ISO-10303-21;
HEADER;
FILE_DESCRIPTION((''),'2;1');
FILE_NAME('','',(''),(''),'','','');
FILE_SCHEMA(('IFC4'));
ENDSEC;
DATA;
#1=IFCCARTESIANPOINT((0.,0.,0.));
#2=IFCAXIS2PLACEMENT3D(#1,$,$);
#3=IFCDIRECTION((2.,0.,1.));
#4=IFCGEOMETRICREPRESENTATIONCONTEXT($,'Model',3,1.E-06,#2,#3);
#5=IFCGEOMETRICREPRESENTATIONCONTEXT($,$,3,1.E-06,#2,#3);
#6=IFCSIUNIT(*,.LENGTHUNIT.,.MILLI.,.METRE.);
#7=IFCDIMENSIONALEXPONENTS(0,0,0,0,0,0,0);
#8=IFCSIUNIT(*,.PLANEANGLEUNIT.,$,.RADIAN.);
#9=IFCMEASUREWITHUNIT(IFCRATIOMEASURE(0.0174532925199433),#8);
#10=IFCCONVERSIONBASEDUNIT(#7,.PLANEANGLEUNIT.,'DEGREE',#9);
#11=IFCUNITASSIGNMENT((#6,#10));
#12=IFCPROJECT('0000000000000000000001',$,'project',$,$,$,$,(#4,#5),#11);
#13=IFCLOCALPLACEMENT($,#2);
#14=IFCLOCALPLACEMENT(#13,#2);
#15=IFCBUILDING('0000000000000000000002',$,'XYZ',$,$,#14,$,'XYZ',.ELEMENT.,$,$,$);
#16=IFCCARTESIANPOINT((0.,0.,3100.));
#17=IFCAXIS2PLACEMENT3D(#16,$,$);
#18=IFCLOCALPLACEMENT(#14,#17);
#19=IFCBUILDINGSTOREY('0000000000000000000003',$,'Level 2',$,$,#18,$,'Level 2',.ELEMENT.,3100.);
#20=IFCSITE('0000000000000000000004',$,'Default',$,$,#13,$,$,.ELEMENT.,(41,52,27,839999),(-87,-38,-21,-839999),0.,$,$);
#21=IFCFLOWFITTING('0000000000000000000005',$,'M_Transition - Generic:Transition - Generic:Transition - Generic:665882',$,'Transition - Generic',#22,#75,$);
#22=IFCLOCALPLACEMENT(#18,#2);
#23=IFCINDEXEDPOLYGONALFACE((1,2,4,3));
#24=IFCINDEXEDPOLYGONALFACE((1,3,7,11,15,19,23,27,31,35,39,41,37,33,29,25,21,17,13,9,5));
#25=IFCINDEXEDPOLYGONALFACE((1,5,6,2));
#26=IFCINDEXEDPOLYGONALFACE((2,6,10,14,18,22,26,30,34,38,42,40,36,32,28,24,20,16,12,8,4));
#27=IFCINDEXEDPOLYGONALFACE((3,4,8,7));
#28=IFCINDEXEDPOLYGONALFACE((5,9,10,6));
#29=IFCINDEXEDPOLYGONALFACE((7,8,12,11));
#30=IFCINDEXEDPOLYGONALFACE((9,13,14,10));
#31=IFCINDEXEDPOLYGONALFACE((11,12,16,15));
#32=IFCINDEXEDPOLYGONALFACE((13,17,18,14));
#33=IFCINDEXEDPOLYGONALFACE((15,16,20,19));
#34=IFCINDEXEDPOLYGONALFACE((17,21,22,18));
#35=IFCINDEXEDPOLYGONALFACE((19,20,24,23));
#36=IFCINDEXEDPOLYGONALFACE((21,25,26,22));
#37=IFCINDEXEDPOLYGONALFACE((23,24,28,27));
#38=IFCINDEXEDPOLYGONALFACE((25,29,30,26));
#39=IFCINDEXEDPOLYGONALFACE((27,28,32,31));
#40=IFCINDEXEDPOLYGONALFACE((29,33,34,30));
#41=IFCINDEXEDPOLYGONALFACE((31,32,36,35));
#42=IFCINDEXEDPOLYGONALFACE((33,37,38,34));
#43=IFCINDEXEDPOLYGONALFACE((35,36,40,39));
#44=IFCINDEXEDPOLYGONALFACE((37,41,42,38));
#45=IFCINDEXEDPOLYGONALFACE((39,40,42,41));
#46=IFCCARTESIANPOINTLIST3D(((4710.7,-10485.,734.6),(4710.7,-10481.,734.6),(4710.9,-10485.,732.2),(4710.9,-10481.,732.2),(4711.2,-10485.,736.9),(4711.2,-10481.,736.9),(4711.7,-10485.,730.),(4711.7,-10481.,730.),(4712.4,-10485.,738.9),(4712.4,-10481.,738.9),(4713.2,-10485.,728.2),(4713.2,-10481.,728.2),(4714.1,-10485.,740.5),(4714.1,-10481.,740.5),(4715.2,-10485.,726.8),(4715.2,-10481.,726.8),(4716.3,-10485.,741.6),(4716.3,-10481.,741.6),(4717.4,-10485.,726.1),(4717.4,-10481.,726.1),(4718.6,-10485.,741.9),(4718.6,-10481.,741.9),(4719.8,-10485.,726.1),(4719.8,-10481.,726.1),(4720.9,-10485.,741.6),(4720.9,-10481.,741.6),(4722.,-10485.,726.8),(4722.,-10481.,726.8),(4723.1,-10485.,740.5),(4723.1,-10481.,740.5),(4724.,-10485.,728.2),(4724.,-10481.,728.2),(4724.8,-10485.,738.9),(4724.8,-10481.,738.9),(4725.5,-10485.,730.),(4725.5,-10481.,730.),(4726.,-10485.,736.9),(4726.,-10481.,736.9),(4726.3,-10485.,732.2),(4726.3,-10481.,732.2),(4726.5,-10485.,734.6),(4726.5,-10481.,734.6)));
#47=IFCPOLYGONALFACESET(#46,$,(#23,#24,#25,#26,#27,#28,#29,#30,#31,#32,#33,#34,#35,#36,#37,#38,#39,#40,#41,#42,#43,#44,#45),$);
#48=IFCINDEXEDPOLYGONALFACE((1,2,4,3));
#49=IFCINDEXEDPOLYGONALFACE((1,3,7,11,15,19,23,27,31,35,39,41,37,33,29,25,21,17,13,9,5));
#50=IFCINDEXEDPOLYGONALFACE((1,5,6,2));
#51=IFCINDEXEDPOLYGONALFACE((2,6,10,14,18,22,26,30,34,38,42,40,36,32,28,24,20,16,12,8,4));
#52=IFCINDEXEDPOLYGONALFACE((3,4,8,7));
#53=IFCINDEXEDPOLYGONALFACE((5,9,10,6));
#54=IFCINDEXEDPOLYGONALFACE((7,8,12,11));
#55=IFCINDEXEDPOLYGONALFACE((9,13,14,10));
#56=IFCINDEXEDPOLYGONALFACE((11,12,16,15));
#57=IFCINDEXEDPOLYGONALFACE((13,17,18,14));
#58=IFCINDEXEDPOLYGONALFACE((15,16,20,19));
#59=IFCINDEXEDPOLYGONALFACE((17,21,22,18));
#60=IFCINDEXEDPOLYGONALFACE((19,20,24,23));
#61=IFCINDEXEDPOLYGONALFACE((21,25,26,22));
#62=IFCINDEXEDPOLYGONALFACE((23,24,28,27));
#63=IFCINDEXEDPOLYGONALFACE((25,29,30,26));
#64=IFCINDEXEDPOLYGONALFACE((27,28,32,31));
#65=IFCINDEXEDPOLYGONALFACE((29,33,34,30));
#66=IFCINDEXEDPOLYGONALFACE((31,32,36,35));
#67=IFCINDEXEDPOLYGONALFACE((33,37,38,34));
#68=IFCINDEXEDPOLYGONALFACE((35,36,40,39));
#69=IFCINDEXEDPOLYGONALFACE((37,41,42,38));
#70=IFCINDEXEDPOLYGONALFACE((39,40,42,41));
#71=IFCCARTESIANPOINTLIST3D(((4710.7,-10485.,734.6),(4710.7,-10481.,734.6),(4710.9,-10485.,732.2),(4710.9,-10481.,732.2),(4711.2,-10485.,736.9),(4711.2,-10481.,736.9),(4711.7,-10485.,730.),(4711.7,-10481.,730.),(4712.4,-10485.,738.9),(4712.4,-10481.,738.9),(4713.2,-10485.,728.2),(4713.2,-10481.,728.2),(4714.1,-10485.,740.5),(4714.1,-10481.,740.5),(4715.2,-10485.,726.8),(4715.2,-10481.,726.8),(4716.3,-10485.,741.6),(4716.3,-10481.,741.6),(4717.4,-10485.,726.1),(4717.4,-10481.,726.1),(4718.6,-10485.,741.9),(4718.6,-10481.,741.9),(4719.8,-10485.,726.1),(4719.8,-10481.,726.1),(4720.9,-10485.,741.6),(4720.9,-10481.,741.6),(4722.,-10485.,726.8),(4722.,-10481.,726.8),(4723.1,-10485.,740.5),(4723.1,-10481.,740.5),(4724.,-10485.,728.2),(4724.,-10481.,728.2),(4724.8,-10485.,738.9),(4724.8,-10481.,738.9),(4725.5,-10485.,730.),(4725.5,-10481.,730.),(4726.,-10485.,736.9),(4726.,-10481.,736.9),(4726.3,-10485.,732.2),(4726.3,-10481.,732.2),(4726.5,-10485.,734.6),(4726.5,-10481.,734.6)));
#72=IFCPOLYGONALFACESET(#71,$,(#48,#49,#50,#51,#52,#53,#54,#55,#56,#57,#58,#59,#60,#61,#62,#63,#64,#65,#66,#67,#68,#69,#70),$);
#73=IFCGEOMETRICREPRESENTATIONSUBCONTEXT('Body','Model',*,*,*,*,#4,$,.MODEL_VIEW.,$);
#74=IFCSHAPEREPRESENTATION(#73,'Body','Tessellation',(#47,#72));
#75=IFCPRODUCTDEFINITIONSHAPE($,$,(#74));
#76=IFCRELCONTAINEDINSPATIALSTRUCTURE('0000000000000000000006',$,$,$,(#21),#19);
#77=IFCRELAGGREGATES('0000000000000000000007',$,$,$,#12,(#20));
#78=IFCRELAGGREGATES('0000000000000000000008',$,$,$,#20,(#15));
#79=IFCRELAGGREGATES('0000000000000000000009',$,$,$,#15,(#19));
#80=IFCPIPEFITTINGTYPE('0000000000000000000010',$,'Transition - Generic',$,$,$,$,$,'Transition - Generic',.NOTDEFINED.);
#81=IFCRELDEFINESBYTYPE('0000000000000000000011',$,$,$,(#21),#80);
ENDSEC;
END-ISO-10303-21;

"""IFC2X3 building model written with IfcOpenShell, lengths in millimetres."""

from ifc_helpers import new_model, entity, si_unit, converted_unit, direction, frame, frame_2d, origin, place, context, subcontext, project, spatial, circle, extrude, source, transform, mapped, type_object, type_shapes, element, save


model = new_model("IFC2X3")

# Units and contexts
model_context = context("Model", 3, precision=1e-06, world=origin(), true_north=direction((2.0, 0.0, 1.0)))
context_of_model = context(None, 3, precision=1e-06, world=origin(), true_north=direction((2.0, 0.0, 1.0)))
body_context = subcontext(model_context, "Body", "Model", "MODEL_VIEW")
ifc_project = project(units=[si_unit("LENGTHUNIT", "METRE", prefix="MILLI"), converted_unit("PLANEANGLEUNIT", "DEGREE", entity("IfcRatioMeasure", 0.0174532925199433), si_unit("PLANEANGLEUNIT", "RADIAN"), dimensions=[0, 0, 0, 0, 0, 0, 0])], contexts=[model_context, context_of_model])

# Site, building, storey
site_placement = place(None, origin())
site = spatial("IfcSite", under=ifc_project, at=site_placement, Name="Default", CompositionType="ELEMENT", RefLatitude=(41, 52, 27, 839999), RefLongitude=(-87, -38, -21, -839999), RefElevation=0.0)
building_placement = place(site_placement, origin())
building = spatial("IfcBuilding", under=site, at=building_placement, Name="XYZ", LongName="XYZ", CompositionType="ELEMENT")
storey_placement = place(building_placement, frame((0.0, 0.0, 3100.0)))
storey = spatial("IfcBuildingStorey", under=building, at=storey_placement, Name="Level 2", LongName="Level 2", CompositionType="ELEMENT", Elevation=3100.0)

# Flow fitting
pipe_fitting_type = type_object("IfcPipeFittingType", Name="Transition - Generic", ElementType="Transition - Generic", PredefinedType="NOTDEFINED")
shared_shape = source(origin(), body_context, "Body", "SweptSolid", [
    extrude(circle(Radius=7.9, at=frame_2d((0.0, 0.0), x_axis=(1.0, 0.0))), frame((0.0, 0.0, 0.0), z_axis=(1.0, 0.0, 0.0), x_axis=(0.0, 0.0, 1.0)), (0.0, 0.0, 1.0), 4.0),
    extrude(circle(Radius=7.9, at=frame_2d((0.0, 0.0), x_axis=(1.0, 0.0))), frame((0.0, 0.0, 0.0), z_axis=(1.0, 0.0, 0.0), x_axis=(0.0, 0.0, 1.0)), (0.0, 0.0, 1.0), 4.0),
])
type_shapes(pipe_fitting_type, [shared_shape])
flow_fitting_placement = place(storey_placement, frame((4718.6, -10481.0, 734.0), z_axis=(0.0, 0.0, 1.0), x_axis=(0.0, -1.0, 0.0)))
element("IfcFlowFitting", 1, at=flow_fitting_placement, inside=storey, type_object=pipe_fitting_type, Name="M_Transition - Generic:Transition - Generic:Transition - Generic:665882", ObjectType="Transition - Generic", context=body_context, shape_type="MappedRepresentation", body=[
    mapped(shared_shape, transform((0.0, 0.0, 0.0), scale=1.0)),
])

save(model, "model.ifc")
